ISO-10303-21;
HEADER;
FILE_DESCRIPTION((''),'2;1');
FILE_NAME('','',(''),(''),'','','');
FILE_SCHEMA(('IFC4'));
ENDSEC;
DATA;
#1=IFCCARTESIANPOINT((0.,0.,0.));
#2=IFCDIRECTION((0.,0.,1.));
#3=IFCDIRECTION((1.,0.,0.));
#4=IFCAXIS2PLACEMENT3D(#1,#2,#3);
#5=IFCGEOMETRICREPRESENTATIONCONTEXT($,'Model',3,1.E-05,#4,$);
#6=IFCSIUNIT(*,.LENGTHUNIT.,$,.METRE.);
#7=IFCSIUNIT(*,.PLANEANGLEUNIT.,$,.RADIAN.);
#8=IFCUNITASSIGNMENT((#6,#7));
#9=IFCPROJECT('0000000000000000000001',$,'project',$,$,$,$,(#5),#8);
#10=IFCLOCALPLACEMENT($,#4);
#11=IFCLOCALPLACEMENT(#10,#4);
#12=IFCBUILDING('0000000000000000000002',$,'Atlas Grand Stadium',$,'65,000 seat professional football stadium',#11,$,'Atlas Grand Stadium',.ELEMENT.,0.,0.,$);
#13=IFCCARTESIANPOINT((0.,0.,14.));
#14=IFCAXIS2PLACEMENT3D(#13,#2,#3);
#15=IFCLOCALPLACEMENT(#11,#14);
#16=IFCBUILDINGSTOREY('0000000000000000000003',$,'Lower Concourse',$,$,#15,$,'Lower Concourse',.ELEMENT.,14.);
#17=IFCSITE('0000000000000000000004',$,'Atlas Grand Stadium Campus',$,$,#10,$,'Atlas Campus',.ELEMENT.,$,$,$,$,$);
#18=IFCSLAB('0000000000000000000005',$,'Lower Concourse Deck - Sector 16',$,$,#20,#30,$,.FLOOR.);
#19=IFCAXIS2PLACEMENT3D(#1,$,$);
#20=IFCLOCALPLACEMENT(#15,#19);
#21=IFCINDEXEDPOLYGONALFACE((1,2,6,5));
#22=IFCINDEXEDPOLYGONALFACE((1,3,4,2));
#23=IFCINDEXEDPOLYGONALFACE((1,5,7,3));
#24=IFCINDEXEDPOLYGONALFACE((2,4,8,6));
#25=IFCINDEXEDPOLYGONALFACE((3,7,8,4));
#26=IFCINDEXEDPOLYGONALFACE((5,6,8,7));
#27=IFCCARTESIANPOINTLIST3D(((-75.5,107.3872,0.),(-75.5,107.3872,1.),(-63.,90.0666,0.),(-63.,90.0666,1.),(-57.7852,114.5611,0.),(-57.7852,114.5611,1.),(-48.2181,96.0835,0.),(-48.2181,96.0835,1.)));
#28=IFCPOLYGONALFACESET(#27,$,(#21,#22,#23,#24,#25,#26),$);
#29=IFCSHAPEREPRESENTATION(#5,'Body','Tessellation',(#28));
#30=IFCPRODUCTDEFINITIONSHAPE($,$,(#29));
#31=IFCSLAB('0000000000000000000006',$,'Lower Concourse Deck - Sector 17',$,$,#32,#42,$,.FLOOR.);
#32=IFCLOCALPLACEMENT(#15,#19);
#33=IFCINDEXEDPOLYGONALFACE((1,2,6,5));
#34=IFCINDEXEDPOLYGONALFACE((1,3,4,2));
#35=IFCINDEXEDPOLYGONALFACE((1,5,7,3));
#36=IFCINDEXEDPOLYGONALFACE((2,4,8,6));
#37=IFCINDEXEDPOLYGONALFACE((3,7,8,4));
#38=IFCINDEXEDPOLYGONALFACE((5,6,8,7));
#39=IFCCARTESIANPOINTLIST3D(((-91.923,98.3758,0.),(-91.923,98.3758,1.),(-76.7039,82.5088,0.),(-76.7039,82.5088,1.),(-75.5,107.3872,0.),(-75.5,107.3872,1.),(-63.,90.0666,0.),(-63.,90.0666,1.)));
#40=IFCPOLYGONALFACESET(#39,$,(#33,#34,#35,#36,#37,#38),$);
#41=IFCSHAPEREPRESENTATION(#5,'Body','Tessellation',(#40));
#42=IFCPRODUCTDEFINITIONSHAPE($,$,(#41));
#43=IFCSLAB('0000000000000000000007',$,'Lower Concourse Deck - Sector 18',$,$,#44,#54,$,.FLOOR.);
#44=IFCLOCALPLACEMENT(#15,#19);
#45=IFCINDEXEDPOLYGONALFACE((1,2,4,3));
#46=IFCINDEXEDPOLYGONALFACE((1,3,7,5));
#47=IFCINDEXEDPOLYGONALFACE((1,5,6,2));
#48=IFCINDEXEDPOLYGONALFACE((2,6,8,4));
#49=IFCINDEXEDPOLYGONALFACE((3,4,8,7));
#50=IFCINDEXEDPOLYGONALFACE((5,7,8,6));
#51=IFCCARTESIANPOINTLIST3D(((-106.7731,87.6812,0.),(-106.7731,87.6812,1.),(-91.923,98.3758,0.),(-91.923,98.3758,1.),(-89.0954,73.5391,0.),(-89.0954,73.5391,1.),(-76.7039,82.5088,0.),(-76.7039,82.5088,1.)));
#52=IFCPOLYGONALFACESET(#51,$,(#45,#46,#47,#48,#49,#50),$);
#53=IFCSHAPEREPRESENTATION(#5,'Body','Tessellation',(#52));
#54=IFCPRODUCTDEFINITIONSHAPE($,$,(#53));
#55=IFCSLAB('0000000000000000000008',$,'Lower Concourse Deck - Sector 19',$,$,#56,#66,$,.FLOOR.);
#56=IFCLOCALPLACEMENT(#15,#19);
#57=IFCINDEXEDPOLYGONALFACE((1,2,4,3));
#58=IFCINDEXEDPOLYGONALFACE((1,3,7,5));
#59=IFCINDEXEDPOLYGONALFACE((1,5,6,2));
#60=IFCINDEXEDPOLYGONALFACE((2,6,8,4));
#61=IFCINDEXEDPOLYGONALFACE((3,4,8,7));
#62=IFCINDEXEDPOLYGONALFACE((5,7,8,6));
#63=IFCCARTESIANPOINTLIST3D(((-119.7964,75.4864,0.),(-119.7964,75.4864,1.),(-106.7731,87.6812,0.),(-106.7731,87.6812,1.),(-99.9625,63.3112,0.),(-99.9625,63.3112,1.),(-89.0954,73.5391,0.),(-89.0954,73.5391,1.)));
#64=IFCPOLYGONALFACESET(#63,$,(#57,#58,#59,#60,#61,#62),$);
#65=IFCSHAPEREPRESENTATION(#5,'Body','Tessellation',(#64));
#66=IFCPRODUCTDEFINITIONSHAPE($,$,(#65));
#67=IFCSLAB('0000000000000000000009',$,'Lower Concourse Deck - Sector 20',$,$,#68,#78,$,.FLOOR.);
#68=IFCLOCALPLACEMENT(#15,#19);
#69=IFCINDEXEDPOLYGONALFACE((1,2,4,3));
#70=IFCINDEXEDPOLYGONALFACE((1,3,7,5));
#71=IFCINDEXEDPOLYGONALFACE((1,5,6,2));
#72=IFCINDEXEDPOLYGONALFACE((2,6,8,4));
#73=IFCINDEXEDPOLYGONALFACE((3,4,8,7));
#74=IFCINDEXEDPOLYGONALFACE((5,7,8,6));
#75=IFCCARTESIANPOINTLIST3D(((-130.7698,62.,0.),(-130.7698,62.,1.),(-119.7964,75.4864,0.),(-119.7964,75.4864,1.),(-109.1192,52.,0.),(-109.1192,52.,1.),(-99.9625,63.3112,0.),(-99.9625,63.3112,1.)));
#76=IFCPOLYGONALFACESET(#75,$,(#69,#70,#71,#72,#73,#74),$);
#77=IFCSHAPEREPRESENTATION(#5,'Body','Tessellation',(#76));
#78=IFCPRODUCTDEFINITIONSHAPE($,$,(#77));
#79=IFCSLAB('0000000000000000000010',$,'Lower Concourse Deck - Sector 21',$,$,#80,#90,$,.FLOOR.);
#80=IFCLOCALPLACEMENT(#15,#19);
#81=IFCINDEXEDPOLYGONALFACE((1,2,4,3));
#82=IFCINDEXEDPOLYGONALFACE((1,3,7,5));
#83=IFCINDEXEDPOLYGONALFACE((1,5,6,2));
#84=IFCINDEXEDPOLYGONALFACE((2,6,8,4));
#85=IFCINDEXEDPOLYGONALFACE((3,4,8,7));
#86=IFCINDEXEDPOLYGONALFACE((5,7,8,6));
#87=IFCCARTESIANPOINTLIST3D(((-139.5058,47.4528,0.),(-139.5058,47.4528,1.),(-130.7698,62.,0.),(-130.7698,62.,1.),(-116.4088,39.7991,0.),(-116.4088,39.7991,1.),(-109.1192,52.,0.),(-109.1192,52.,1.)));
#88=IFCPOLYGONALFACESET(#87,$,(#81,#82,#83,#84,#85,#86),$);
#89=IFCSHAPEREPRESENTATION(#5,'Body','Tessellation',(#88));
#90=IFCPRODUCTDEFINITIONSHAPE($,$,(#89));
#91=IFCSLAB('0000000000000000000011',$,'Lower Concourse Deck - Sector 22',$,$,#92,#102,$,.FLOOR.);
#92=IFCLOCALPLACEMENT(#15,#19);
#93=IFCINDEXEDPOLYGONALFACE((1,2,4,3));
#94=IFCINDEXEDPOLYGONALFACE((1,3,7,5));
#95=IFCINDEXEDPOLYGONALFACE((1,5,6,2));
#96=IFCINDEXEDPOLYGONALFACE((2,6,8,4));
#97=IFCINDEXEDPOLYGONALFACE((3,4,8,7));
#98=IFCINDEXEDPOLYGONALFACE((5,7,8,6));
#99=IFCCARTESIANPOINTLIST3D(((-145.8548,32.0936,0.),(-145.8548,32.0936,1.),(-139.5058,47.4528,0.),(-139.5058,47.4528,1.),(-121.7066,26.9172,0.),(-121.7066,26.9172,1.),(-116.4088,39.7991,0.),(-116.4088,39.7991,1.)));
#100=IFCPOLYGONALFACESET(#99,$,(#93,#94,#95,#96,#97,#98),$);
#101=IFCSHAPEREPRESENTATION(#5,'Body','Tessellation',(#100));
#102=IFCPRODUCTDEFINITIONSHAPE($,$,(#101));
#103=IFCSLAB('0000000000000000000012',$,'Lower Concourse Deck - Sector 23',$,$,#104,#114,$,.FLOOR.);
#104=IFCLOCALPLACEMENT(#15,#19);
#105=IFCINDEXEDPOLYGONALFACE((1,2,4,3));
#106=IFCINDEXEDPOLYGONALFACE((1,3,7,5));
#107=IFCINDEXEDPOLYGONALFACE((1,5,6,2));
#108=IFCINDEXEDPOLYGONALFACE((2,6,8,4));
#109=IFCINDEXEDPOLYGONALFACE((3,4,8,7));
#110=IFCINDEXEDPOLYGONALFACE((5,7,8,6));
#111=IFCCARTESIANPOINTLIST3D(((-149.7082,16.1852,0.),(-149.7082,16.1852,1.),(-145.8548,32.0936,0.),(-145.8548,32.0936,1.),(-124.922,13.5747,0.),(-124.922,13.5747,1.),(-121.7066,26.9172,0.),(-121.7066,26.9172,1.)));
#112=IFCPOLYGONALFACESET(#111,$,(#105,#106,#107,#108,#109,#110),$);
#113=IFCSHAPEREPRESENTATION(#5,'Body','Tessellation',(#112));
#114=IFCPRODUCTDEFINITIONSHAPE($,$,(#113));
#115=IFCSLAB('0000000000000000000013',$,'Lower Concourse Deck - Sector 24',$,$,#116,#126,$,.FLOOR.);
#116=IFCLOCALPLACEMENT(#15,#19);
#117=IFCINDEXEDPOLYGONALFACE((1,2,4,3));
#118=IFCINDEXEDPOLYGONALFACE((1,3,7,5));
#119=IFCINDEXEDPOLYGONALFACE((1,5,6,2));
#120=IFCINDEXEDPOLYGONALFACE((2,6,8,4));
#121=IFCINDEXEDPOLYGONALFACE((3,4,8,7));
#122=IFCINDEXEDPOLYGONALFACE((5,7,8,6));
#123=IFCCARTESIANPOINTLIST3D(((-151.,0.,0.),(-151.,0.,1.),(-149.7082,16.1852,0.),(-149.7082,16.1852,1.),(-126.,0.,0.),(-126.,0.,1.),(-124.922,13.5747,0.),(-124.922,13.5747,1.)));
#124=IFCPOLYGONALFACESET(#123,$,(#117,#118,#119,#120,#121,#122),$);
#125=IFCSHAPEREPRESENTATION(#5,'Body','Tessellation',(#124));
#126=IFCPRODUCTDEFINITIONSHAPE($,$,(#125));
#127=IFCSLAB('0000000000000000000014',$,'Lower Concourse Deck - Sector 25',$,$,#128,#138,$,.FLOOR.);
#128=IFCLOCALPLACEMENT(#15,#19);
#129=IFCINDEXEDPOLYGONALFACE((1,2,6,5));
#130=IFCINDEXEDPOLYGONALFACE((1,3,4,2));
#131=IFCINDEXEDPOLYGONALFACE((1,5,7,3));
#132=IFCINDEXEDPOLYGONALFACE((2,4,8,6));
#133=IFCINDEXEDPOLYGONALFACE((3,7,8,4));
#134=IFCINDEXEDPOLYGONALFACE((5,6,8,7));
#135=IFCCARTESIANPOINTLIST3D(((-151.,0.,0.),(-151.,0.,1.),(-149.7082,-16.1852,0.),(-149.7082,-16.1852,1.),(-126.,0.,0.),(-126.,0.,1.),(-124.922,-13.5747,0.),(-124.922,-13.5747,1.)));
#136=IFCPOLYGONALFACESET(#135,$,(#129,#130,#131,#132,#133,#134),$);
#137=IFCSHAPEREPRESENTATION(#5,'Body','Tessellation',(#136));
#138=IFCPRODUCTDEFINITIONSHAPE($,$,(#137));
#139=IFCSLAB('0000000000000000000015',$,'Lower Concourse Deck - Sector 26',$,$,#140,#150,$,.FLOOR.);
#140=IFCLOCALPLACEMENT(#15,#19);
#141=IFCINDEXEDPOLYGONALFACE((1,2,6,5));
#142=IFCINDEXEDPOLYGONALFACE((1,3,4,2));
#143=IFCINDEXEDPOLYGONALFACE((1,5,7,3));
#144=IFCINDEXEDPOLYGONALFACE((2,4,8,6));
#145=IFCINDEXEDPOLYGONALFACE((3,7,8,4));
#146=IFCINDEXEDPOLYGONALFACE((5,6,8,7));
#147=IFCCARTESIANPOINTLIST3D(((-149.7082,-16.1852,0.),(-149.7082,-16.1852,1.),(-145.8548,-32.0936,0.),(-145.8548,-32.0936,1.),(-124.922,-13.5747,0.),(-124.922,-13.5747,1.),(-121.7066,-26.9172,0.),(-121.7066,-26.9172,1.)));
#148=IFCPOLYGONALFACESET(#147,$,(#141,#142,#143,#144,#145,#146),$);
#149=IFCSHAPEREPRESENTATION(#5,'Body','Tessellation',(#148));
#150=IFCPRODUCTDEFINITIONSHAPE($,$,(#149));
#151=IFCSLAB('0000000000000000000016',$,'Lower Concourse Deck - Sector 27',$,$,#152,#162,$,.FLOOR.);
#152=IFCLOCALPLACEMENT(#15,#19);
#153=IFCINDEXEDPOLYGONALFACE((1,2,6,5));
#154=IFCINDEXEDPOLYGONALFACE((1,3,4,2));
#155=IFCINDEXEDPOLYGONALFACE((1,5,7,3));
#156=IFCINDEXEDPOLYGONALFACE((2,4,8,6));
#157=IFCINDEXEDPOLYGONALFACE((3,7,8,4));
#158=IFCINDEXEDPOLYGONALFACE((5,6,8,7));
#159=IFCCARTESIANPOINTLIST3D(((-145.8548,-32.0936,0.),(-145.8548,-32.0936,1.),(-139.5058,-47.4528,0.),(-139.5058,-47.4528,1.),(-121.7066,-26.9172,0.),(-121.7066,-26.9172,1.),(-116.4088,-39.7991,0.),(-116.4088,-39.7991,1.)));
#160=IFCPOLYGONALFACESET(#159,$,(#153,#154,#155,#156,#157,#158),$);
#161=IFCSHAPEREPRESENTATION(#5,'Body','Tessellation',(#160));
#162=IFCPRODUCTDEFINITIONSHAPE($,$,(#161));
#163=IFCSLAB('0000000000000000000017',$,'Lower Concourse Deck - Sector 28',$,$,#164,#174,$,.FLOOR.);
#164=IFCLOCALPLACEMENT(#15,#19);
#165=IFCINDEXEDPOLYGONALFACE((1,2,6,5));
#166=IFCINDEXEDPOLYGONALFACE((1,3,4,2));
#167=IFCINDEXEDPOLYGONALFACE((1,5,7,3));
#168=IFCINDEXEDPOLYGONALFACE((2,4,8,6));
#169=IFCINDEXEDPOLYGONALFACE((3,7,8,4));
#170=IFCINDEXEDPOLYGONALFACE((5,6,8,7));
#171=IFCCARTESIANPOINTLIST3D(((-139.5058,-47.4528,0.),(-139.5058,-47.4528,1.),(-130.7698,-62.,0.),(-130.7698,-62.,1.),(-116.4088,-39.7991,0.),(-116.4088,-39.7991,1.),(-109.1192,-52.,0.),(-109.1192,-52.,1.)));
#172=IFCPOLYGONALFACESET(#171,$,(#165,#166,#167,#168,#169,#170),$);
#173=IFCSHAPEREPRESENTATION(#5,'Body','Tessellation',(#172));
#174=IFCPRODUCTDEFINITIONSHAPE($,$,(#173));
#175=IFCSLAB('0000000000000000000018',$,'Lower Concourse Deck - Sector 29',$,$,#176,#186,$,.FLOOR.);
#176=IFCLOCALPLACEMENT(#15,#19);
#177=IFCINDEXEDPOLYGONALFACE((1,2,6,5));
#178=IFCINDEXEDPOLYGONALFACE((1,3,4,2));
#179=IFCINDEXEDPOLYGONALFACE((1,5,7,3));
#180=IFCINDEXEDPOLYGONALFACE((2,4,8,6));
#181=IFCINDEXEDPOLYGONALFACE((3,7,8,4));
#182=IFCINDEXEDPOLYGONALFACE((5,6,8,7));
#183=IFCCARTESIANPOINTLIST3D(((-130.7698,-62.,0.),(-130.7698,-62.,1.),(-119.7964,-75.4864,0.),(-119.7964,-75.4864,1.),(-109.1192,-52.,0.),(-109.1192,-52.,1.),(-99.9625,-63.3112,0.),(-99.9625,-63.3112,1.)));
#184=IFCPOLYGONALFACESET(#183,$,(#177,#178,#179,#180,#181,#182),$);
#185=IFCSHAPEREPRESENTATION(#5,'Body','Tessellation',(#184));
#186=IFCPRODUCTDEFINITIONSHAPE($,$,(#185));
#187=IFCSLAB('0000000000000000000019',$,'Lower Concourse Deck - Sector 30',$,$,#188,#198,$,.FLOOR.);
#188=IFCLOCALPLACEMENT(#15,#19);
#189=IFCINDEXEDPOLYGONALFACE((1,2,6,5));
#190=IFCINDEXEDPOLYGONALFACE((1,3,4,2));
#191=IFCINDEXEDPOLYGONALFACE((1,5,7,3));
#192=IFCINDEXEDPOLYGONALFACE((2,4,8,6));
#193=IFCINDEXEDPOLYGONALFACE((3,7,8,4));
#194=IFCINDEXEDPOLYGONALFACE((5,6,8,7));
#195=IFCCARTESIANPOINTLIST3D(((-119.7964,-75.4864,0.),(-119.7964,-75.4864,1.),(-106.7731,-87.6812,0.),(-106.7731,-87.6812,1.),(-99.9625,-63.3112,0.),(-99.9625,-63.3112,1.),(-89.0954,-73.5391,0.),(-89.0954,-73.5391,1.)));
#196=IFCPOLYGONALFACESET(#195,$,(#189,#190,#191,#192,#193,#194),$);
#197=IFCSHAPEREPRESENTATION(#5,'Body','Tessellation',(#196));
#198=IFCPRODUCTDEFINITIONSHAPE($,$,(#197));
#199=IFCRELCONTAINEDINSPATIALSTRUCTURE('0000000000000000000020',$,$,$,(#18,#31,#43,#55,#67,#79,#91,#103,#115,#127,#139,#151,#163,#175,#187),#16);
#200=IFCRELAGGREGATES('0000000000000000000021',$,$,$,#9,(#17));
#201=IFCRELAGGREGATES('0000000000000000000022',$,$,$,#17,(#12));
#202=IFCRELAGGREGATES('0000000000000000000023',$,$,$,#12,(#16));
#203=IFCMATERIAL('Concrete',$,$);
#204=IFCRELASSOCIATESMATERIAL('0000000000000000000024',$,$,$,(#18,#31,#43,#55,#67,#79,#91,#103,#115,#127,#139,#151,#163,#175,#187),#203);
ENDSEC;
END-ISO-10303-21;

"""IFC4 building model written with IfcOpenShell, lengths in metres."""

from ifc_helpers import new_model, si_unit, frame, origin_with_axes, place, context, project, spatial, polyline, outline, extrude, material, element, save


model = new_model("IFC4")

# Units and contexts
model_context = context("Model", 3, precision=1e-05, world=origin_with_axes())
ifc_project = project(units=[si_unit("LENGTHUNIT", "METRE"), si_unit("PLANEANGLEUNIT", "RADIAN")], contexts=[model_context])

# Site, building, storey
site_placement = place(None, origin_with_axes())
site = spatial("IfcSite", under=ifc_project, at=site_placement, Name="Atlas Grand Stadium Campus", LongName="Atlas Campus", CompositionType="ELEMENT")
building_placement = place(site_placement, origin_with_axes())
building = spatial("IfcBuilding", under=site, at=building_placement, Name="Atlas Grand Stadium", ObjectType="65,000 seat professional football stadium", LongName="Atlas Grand Stadium", CompositionType="ELEMENT", ElevationOfRefHeight=0.0, ElevationOfTerrain=0.0)
storey_placement = place(building_placement, frame((0.0, 0.0, 14.0), z_axis=(0.0, 0.0, 1.0), x_axis=(1.0, 0.0, 0.0)))
storey = spatial("IfcBuildingStorey", under=building, at=storey_placement, Name="Lower Concourse", LongName="Lower Concourse", CompositionType="ELEMENT", Elevation=14.0)

# Slabs
ifc_material = material(Name="Concrete")
slab_1_placement = place(storey_placement, origin_with_axes())
element("IfcSlab", 1, at=slab_1_placement, inside=storey, material=ifc_material, Name="Lower Concourse Deck - Sector 16", PredefinedType="FLOOR", context=model_context, shape_type="SweptSolid", body=[
    extrude(outline(polyline([(-57.7852, 114.5611), (-75.5, 107.3872), (-63.0, 90.0666), (-48.2181, 96.0835), (-57.7852, 114.5611)])), origin_with_axes(), (0.0, 0.0, 1.0), 1.0),
])
slab_2_placement = place(storey_placement, origin_with_axes())
element("IfcSlab", 2, at=slab_2_placement, inside=storey, material=ifc_material, Name="Lower Concourse Deck - Sector 17", PredefinedType="FLOOR", context=model_context, shape_type="SweptSolid", body=[
    extrude(outline(polyline([(-75.5, 107.3872), (-91.923, 98.3758), (-76.7039, 82.5088), (-63.0, 90.0666), (-75.5, 107.3872)])), origin_with_axes(), (0.0, 0.0, 1.0), 1.0),
])
slab_3_placement = place(storey_placement, origin_with_axes())
element("IfcSlab", 3, at=slab_3_placement, inside=storey, material=ifc_material, Name="Lower Concourse Deck - Sector 18", PredefinedType="FLOOR", context=model_context, shape_type="SweptSolid", body=[
    extrude(outline(polyline([(-91.923, 98.3758), (-106.7731, 87.6812), (-89.0954, 73.5391), (-76.7039, 82.5088), (-91.923, 98.3758)])), origin_with_axes(), (0.0, 0.0, 1.0), 1.0),
])
slab_4_placement = place(storey_placement, origin_with_axes())
element("IfcSlab", 4, at=slab_4_placement, inside=storey, material=ifc_material, Name="Lower Concourse Deck - Sector 19", PredefinedType="FLOOR", context=model_context, shape_type="SweptSolid", body=[
    extrude(outline(polyline([(-106.7731, 87.6812), (-119.7964, 75.4864), (-99.9625, 63.3112), (-89.0954, 73.5391), (-106.7731, 87.6812)])), origin_with_axes(), (0.0, 0.0, 1.0), 1.0),
])
slab_5_placement = place(storey_placement, origin_with_axes())
element("IfcSlab", 5, at=slab_5_placement, inside=storey, material=ifc_material, Name="Lower Concourse Deck - Sector 20", PredefinedType="FLOOR", context=model_context, shape_type="SweptSolid", body=[
    extrude(outline(polyline([(-119.7964, 75.4864), (-130.7698, 62.0), (-109.1192, 52.0), (-99.9625, 63.3112), (-119.7964, 75.4864)])), origin_with_axes(), (0.0, 0.0, 1.0), 1.0),
])
slab_6_placement = place(storey_placement, origin_with_axes())
element("IfcSlab", 6, at=slab_6_placement, inside=storey, material=ifc_material, Name="Lower Concourse Deck - Sector 21", PredefinedType="FLOOR", context=model_context, shape_type="SweptSolid", body=[
    extrude(outline(polyline([(-130.7698, 62.0), (-139.5058, 47.4528), (-116.4088, 39.7991), (-109.1192, 52.0), (-130.7698, 62.0)])), origin_with_axes(), (0.0, 0.0, 1.0), 1.0),
])
slab_7_placement = place(storey_placement, origin_with_axes())
element("IfcSlab", 7, at=slab_7_placement, inside=storey, material=ifc_material, Name="Lower Concourse Deck - Sector 22", PredefinedType="FLOOR", context=model_context, shape_type="SweptSolid", body=[
    extrude(outline(polyline([(-139.5058, 47.4528), (-145.8548, 32.0936), (-121.7066, 26.9172), (-116.4088, 39.7991), (-139.5058, 47.4528)])), origin_with_axes(), (0.0, 0.0, 1.0), 1.0),
])
slab_8_placement = place(storey_placement, origin_with_axes())
element("IfcSlab", 8, at=slab_8_placement, inside=storey, material=ifc_material, Name="Lower Concourse Deck - Sector 23", PredefinedType="FLOOR", context=model_context, shape_type="SweptSolid", body=[
    extrude(outline(polyline([(-145.8548, 32.0936), (-149.7082, 16.1852), (-124.922, 13.5747), (-121.7066, 26.9172), (-145.8548, 32.0936)])), origin_with_axes(), (0.0, 0.0, 1.0), 1.0),
])
slab_9_placement = place(storey_placement, origin_with_axes())
element("IfcSlab", 9, at=slab_9_placement, inside=storey, material=ifc_material, Name="Lower Concourse Deck - Sector 24", PredefinedType="FLOOR", context=model_context, shape_type="SweptSolid", body=[
    extrude(outline(polyline([(-149.7082, 16.1852), (-151.0, 0.0), (-126.0, 0.0), (-124.922, 13.5747), (-149.7082, 16.1852)])), origin_with_axes(), (0.0, 0.0, 1.0), 1.0),
])
slab_10_placement = place(storey_placement, origin_with_axes())
element("IfcSlab", 10, at=slab_10_placement, inside=storey, material=ifc_material, Name="Lower Concourse Deck - Sector 25", PredefinedType="FLOOR", context=model_context, shape_type="SweptSolid", body=[
    extrude(outline(polyline([(-151.0, 0.0), (-149.7082, -16.1852), (-124.922, -13.5747), (-126.0, 0.0), (-151.0, 0.0)])), origin_with_axes(), (0.0, 0.0, 1.0), 1.0),
])
slab_11_placement = place(storey_placement, origin_with_axes())
element("IfcSlab", 11, at=slab_11_placement, inside=storey, material=ifc_material, Name="Lower Concourse Deck - Sector 26", PredefinedType="FLOOR", context=model_context, shape_type="SweptSolid", body=[
    extrude(outline(polyline([(-149.7082, -16.1852), (-145.8548, -32.0936), (-121.7066, -26.9172), (-124.922, -13.5747), (-149.7082, -16.1852)])), origin_with_axes(), (0.0, 0.0, 1.0), 1.0),
])
slab_12_placement = place(storey_placement, origin_with_axes())
element("IfcSlab", 12, at=slab_12_placement, inside=storey, material=ifc_material, Name="Lower Concourse Deck - Sector 27", PredefinedType="FLOOR", context=model_context, shape_type="SweptSolid", body=[
    extrude(outline(polyline([(-145.8548, -32.0936), (-139.5058, -47.4528), (-116.4088, -39.7991), (-121.7066, -26.9172), (-145.8548, -32.0936)])), origin_with_axes(), (0.0, 0.0, 1.0), 1.0),
])
slab_13_placement = place(storey_placement, origin_with_axes())
element("IfcSlab", 13, at=slab_13_placement, inside=storey, material=ifc_material, Name="Lower Concourse Deck - Sector 28", PredefinedType="FLOOR", context=model_context, shape_type="SweptSolid", body=[
    extrude(outline(polyline([(-139.5058, -47.4528), (-130.7698, -62.0), (-109.1192, -52.0), (-116.4088, -39.7991), (-139.5058, -47.4528)])), origin_with_axes(), (0.0, 0.0, 1.0), 1.0),
])
slab_14_placement = place(storey_placement, origin_with_axes())
element("IfcSlab", 14, at=slab_14_placement, inside=storey, material=ifc_material, Name="Lower Concourse Deck - Sector 29", PredefinedType="FLOOR", context=model_context, shape_type="SweptSolid", body=[
    extrude(outline(polyline([(-130.7698, -62.0), (-119.7964, -75.4864), (-99.9625, -63.3112), (-109.1192, -52.0), (-130.7698, -62.0)])), origin_with_axes(), (0.0, 0.0, 1.0), 1.0),
])
slab_15_placement = place(storey_placement, origin_with_axes())
element("IfcSlab", 15, at=slab_15_placement, inside=storey, material=ifc_material, Name="Lower Concourse Deck - Sector 30", PredefinedType="FLOOR", context=model_context, shape_type="SweptSolid", body=[
    extrude(outline(polyline([(-119.7964, -75.4864), (-106.7731, -87.6812), (-89.0954, -73.5391), (-99.9625, -63.3112), (-119.7964, -75.4864)])), origin_with_axes(), (0.0, 0.0, 1.0), 1.0),
])

save(model, "model.ifc")
